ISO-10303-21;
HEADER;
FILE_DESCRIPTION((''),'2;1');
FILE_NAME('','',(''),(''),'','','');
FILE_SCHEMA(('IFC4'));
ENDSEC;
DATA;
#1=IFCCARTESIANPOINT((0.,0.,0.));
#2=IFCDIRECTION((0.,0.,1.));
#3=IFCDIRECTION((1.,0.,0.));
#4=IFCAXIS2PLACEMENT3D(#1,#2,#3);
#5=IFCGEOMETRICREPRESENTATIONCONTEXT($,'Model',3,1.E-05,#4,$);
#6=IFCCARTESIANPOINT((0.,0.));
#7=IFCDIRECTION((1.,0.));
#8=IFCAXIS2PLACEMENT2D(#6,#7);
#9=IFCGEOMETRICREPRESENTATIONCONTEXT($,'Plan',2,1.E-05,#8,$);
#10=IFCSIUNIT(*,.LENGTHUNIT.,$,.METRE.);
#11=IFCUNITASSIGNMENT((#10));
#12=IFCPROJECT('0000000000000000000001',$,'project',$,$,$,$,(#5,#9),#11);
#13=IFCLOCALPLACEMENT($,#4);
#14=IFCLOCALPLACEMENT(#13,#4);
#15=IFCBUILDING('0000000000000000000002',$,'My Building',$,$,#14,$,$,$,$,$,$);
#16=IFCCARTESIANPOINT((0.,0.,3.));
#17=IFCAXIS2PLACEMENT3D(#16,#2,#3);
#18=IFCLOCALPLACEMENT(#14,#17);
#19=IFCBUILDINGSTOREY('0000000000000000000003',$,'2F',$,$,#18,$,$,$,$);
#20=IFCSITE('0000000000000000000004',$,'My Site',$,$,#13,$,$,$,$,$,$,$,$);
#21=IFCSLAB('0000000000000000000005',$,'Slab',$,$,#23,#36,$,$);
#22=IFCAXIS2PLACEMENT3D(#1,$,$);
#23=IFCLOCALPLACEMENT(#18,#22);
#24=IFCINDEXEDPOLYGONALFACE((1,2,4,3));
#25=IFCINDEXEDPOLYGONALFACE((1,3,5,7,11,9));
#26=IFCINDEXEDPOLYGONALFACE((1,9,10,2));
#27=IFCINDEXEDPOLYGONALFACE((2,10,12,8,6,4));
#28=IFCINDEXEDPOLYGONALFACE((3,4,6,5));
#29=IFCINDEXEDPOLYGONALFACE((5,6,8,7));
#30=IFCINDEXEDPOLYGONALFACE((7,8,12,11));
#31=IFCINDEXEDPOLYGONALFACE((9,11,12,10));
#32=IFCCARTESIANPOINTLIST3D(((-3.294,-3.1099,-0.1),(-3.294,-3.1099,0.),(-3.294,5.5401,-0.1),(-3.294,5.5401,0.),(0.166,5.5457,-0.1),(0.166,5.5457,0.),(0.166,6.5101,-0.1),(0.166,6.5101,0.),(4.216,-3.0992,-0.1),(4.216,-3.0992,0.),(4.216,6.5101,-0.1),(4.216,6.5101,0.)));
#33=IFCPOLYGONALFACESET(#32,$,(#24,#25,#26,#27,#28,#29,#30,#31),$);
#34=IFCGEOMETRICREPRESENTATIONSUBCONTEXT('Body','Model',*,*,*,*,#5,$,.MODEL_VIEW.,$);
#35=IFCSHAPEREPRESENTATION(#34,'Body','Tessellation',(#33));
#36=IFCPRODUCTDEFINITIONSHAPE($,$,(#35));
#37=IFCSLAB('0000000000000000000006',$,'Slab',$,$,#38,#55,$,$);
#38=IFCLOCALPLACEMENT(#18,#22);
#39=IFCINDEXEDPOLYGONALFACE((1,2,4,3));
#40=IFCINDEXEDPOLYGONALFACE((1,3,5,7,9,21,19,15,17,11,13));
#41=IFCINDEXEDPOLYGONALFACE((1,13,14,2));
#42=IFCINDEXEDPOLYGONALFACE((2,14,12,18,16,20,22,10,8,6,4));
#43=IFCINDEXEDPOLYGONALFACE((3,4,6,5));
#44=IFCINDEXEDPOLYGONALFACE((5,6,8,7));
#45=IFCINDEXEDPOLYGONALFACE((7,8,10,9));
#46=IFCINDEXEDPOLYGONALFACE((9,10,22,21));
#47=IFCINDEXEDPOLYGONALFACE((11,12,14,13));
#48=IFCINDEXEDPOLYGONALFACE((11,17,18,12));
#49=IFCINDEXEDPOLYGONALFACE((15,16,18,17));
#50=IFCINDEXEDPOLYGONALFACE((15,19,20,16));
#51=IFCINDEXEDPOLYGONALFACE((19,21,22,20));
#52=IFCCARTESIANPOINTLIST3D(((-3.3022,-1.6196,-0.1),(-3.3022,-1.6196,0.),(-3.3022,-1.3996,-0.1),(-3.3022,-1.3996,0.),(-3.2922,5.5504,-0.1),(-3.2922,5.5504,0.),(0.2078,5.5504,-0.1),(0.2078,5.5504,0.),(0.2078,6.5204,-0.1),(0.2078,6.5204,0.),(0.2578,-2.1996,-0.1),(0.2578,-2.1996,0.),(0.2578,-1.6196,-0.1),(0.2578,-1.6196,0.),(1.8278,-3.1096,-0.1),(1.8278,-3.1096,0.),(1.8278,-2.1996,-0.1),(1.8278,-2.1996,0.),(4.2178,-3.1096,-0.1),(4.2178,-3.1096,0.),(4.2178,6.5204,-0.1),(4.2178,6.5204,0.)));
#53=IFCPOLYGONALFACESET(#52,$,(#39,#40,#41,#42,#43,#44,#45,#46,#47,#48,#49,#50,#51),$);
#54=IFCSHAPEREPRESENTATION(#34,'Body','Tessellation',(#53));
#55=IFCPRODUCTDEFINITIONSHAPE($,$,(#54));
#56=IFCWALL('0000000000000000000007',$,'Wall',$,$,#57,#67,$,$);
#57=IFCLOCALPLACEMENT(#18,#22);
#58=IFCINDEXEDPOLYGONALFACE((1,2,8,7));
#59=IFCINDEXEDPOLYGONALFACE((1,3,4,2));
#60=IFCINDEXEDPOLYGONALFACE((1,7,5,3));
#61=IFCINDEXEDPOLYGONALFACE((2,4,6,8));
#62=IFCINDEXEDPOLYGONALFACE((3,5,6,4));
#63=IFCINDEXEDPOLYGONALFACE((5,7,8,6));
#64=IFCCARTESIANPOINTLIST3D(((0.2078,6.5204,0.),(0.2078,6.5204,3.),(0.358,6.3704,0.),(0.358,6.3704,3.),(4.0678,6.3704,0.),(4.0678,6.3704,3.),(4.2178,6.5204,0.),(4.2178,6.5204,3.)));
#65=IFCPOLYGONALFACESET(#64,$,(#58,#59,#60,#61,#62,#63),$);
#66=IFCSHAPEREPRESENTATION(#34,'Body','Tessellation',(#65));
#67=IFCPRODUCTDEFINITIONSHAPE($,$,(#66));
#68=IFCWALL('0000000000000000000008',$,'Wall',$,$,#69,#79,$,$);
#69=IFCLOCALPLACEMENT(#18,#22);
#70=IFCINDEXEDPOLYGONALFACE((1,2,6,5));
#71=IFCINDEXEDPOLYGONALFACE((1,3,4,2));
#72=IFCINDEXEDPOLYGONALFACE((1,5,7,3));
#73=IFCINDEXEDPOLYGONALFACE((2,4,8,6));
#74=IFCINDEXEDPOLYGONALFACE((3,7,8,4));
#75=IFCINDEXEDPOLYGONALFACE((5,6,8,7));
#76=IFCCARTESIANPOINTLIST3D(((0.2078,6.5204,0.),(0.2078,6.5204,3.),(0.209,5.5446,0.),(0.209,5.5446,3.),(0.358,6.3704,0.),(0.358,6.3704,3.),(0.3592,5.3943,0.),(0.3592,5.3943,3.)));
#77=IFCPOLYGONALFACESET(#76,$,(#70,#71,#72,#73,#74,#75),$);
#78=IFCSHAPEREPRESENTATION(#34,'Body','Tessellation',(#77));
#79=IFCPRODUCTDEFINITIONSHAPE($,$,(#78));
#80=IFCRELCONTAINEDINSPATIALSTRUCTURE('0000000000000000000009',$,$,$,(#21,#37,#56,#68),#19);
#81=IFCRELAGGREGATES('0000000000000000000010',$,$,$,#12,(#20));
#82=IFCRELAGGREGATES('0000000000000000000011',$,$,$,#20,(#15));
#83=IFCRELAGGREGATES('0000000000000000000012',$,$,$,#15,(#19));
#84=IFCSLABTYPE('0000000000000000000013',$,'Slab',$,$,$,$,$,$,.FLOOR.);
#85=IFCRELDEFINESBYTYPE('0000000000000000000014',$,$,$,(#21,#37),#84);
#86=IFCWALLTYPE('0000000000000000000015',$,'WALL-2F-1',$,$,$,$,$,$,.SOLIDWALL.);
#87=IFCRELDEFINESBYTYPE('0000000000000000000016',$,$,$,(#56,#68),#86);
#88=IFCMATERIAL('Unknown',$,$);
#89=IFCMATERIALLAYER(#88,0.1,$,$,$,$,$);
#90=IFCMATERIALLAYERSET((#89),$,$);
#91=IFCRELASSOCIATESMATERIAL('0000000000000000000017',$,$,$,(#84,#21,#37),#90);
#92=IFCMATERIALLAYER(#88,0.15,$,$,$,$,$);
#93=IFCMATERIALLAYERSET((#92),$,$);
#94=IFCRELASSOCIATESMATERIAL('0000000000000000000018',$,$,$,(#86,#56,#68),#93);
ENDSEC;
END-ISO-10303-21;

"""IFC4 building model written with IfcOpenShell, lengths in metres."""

from ifc_helpers import new_model, si_unit, frame, origin_with_axes, origin_2d_with_axis, place, context, subcontext, project, spatial, line, indexed_curve, outline, extrude, material, layer, layer_set, layer_usage, type_object, element, save


model = new_model("IFC4")

# Units and contexts
model_context = context("Model", 3, precision=1e-05, world=origin_with_axes())
plan_context = context("Plan", 2, precision=1e-05, world=origin_2d_with_axis())
body_context_1 = subcontext(model_context, "Body", "Model", "MODEL_VIEW")
ifc_project = project(units=[si_unit("LENGTHUNIT", "METRE")], contexts=[model_context, plan_context])

# Site, building, storey
site_placement = place(None, origin_with_axes())
site = spatial("IfcSite", under=ifc_project, at=site_placement, Name="My Site")
building_placement = place(site_placement, origin_with_axes())
building = spatial("IfcBuilding", under=site, at=building_placement, Name="My Building")
storey_placement = place(building_placement, frame((0.0, 0.0, 3.0), z_axis=(0.0, 0.0, 1.0), x_axis=(1.0, 0.0, 0.0)))
storey = spatial("IfcBuildingStorey", under=building, at=storey_placement, Name="2F")

# Slabs
ifc_material = material(Name="Unknown")
ifc_layer_1 = layer(ifc_material, 0.1)
ifc_layer_set_1 = layer_set([ifc_layer_1])
ifc_layer_usage_1 = layer_usage(ifc_layer_set_1, "AXIS3", "POSITIVE", -0.1)
slab_type = type_object("IfcSlabType", Name="Slab", PredefinedType="FLOOR", material=ifc_layer_set_1)
slab_1_placement = place(storey_placement, frame((-3.294, 5.5401, 0.0), z_axis=(0.0, 0.0, 1.0), x_axis=(1.0, 0.0, 0.0)))
element("IfcSlab", 1, at=slab_1_placement, inside=storey, type_object=slab_type, material=ifc_layer_usage_1, Name="Slab", context=body_context_1, shape_type="SweptSolid", body=[
    extrude(outline(indexed_curve([(0.0, 0.0), (0.0, -8.65), (7.51, -8.6394), (7.51, 0.97), (3.46, 0.97), (3.46, 0.0056), (0.0, 0.0)])), frame((0.0, 0.0, -0.1), z_axis=(0.0, 0.0, 1.0), x_axis=(1.0, 0.0, 0.0)), (0.0, 0.0, 1.0), 0.1),
])
ifc_layer_usage_2 = layer_usage(ifc_layer_set_1, "AXIS3", "POSITIVE", -0.1)
slab_2_placement = place(storey_placement, frame((-3.3022, -1.3996, 0.0), z_axis=(0.0, 0.0, 1.0), x_axis=(1.0, 0.0, 0.0)))
element("IfcSlab", 2, at=slab_2_placement, inside=storey, type_object=slab_type, material=ifc_layer_usage_2, Name="Slab", context=body_context_1, shape_type="SweptSolid", body=[
    extrude(outline(indexed_curve([(0.0, 0.0), (0.0, -0.22), (3.56, -0.22), (3.56, -0.8), (5.13, -0.8), (5.13, -1.71), (7.52, -1.71), (7.52, 7.92), (3.51, 7.92), (3.51, 6.95), (0.01, 6.95), (0.0, 0.0)])), frame((0.0, 0.0, -0.1), z_axis=(0.0, 0.0, 1.0), x_axis=(1.0, 0.0, 0.0)), (0.0, 0.0, 1.0), 0.1),
])

# Shared definitions
ifc_layer_2 = layer(ifc_material, 0.15)
ifc_layer_set_2 = layer_set([ifc_layer_2])
wall_type_1 = type_object("IfcWallType", Name="WALL-2F-1", PredefinedType="SOLIDWALL", material=ifc_layer_set_2)

# Walls
ifc_layer_usage_3 = layer_usage(ifc_layer_set_2, "AXIS2", "POSITIVE", 0.0)
wall_1_placement = place(storey_placement, frame((4.2178, 6.5204, 0.0), z_axis=(0.0, 0.0, 1.0), x_axis=(-1.0, 0.0, 0.0)))
element("IfcWall", 3, at=wall_1_placement, inside=storey, type_object=wall_type_1, material=ifc_layer_usage_3, Name="Wall", context=body_context_1, shape_type="SweptSolid", body=[
    extrude(outline(indexed_curve([(0.0, 0.0), (0.15, 0.15), (3.8598, 0.15), (4.01, 0.0)], segments=[line(1, 2, 3, 4, 1)])), origin_with_axes(), (0.0, 0.0, 1.0), 3.0),
])
ifc_layer_usage_4 = layer_usage(ifc_layer_set_2, "AXIS2", "POSITIVE", 0.0)
wall_2_placement = place(storey_placement, frame((0.2078, 6.5204, 0.0), z_axis=(0.0, 0.0, 1.0), x_axis=(0.001246, -0.999999, 0.0)))
element("IfcWall", 4, at=wall_2_placement, inside=storey, type_object=wall_type_1, material=ifc_layer_usage_4, Name="Wall", context=body_context_1, shape_type="SweptSolid", body=[
    extrude(outline(indexed_curve([(0.0, 0.0), (0.1502, 0.15), (1.1263, 0.15), (0.9758, 0.0)], segments=[line(1, 2, 3, 4, 1)])), origin_with_axes(), (0.0, 0.0, 1.0), 3.0),
])

save(model, "model.ifc")
